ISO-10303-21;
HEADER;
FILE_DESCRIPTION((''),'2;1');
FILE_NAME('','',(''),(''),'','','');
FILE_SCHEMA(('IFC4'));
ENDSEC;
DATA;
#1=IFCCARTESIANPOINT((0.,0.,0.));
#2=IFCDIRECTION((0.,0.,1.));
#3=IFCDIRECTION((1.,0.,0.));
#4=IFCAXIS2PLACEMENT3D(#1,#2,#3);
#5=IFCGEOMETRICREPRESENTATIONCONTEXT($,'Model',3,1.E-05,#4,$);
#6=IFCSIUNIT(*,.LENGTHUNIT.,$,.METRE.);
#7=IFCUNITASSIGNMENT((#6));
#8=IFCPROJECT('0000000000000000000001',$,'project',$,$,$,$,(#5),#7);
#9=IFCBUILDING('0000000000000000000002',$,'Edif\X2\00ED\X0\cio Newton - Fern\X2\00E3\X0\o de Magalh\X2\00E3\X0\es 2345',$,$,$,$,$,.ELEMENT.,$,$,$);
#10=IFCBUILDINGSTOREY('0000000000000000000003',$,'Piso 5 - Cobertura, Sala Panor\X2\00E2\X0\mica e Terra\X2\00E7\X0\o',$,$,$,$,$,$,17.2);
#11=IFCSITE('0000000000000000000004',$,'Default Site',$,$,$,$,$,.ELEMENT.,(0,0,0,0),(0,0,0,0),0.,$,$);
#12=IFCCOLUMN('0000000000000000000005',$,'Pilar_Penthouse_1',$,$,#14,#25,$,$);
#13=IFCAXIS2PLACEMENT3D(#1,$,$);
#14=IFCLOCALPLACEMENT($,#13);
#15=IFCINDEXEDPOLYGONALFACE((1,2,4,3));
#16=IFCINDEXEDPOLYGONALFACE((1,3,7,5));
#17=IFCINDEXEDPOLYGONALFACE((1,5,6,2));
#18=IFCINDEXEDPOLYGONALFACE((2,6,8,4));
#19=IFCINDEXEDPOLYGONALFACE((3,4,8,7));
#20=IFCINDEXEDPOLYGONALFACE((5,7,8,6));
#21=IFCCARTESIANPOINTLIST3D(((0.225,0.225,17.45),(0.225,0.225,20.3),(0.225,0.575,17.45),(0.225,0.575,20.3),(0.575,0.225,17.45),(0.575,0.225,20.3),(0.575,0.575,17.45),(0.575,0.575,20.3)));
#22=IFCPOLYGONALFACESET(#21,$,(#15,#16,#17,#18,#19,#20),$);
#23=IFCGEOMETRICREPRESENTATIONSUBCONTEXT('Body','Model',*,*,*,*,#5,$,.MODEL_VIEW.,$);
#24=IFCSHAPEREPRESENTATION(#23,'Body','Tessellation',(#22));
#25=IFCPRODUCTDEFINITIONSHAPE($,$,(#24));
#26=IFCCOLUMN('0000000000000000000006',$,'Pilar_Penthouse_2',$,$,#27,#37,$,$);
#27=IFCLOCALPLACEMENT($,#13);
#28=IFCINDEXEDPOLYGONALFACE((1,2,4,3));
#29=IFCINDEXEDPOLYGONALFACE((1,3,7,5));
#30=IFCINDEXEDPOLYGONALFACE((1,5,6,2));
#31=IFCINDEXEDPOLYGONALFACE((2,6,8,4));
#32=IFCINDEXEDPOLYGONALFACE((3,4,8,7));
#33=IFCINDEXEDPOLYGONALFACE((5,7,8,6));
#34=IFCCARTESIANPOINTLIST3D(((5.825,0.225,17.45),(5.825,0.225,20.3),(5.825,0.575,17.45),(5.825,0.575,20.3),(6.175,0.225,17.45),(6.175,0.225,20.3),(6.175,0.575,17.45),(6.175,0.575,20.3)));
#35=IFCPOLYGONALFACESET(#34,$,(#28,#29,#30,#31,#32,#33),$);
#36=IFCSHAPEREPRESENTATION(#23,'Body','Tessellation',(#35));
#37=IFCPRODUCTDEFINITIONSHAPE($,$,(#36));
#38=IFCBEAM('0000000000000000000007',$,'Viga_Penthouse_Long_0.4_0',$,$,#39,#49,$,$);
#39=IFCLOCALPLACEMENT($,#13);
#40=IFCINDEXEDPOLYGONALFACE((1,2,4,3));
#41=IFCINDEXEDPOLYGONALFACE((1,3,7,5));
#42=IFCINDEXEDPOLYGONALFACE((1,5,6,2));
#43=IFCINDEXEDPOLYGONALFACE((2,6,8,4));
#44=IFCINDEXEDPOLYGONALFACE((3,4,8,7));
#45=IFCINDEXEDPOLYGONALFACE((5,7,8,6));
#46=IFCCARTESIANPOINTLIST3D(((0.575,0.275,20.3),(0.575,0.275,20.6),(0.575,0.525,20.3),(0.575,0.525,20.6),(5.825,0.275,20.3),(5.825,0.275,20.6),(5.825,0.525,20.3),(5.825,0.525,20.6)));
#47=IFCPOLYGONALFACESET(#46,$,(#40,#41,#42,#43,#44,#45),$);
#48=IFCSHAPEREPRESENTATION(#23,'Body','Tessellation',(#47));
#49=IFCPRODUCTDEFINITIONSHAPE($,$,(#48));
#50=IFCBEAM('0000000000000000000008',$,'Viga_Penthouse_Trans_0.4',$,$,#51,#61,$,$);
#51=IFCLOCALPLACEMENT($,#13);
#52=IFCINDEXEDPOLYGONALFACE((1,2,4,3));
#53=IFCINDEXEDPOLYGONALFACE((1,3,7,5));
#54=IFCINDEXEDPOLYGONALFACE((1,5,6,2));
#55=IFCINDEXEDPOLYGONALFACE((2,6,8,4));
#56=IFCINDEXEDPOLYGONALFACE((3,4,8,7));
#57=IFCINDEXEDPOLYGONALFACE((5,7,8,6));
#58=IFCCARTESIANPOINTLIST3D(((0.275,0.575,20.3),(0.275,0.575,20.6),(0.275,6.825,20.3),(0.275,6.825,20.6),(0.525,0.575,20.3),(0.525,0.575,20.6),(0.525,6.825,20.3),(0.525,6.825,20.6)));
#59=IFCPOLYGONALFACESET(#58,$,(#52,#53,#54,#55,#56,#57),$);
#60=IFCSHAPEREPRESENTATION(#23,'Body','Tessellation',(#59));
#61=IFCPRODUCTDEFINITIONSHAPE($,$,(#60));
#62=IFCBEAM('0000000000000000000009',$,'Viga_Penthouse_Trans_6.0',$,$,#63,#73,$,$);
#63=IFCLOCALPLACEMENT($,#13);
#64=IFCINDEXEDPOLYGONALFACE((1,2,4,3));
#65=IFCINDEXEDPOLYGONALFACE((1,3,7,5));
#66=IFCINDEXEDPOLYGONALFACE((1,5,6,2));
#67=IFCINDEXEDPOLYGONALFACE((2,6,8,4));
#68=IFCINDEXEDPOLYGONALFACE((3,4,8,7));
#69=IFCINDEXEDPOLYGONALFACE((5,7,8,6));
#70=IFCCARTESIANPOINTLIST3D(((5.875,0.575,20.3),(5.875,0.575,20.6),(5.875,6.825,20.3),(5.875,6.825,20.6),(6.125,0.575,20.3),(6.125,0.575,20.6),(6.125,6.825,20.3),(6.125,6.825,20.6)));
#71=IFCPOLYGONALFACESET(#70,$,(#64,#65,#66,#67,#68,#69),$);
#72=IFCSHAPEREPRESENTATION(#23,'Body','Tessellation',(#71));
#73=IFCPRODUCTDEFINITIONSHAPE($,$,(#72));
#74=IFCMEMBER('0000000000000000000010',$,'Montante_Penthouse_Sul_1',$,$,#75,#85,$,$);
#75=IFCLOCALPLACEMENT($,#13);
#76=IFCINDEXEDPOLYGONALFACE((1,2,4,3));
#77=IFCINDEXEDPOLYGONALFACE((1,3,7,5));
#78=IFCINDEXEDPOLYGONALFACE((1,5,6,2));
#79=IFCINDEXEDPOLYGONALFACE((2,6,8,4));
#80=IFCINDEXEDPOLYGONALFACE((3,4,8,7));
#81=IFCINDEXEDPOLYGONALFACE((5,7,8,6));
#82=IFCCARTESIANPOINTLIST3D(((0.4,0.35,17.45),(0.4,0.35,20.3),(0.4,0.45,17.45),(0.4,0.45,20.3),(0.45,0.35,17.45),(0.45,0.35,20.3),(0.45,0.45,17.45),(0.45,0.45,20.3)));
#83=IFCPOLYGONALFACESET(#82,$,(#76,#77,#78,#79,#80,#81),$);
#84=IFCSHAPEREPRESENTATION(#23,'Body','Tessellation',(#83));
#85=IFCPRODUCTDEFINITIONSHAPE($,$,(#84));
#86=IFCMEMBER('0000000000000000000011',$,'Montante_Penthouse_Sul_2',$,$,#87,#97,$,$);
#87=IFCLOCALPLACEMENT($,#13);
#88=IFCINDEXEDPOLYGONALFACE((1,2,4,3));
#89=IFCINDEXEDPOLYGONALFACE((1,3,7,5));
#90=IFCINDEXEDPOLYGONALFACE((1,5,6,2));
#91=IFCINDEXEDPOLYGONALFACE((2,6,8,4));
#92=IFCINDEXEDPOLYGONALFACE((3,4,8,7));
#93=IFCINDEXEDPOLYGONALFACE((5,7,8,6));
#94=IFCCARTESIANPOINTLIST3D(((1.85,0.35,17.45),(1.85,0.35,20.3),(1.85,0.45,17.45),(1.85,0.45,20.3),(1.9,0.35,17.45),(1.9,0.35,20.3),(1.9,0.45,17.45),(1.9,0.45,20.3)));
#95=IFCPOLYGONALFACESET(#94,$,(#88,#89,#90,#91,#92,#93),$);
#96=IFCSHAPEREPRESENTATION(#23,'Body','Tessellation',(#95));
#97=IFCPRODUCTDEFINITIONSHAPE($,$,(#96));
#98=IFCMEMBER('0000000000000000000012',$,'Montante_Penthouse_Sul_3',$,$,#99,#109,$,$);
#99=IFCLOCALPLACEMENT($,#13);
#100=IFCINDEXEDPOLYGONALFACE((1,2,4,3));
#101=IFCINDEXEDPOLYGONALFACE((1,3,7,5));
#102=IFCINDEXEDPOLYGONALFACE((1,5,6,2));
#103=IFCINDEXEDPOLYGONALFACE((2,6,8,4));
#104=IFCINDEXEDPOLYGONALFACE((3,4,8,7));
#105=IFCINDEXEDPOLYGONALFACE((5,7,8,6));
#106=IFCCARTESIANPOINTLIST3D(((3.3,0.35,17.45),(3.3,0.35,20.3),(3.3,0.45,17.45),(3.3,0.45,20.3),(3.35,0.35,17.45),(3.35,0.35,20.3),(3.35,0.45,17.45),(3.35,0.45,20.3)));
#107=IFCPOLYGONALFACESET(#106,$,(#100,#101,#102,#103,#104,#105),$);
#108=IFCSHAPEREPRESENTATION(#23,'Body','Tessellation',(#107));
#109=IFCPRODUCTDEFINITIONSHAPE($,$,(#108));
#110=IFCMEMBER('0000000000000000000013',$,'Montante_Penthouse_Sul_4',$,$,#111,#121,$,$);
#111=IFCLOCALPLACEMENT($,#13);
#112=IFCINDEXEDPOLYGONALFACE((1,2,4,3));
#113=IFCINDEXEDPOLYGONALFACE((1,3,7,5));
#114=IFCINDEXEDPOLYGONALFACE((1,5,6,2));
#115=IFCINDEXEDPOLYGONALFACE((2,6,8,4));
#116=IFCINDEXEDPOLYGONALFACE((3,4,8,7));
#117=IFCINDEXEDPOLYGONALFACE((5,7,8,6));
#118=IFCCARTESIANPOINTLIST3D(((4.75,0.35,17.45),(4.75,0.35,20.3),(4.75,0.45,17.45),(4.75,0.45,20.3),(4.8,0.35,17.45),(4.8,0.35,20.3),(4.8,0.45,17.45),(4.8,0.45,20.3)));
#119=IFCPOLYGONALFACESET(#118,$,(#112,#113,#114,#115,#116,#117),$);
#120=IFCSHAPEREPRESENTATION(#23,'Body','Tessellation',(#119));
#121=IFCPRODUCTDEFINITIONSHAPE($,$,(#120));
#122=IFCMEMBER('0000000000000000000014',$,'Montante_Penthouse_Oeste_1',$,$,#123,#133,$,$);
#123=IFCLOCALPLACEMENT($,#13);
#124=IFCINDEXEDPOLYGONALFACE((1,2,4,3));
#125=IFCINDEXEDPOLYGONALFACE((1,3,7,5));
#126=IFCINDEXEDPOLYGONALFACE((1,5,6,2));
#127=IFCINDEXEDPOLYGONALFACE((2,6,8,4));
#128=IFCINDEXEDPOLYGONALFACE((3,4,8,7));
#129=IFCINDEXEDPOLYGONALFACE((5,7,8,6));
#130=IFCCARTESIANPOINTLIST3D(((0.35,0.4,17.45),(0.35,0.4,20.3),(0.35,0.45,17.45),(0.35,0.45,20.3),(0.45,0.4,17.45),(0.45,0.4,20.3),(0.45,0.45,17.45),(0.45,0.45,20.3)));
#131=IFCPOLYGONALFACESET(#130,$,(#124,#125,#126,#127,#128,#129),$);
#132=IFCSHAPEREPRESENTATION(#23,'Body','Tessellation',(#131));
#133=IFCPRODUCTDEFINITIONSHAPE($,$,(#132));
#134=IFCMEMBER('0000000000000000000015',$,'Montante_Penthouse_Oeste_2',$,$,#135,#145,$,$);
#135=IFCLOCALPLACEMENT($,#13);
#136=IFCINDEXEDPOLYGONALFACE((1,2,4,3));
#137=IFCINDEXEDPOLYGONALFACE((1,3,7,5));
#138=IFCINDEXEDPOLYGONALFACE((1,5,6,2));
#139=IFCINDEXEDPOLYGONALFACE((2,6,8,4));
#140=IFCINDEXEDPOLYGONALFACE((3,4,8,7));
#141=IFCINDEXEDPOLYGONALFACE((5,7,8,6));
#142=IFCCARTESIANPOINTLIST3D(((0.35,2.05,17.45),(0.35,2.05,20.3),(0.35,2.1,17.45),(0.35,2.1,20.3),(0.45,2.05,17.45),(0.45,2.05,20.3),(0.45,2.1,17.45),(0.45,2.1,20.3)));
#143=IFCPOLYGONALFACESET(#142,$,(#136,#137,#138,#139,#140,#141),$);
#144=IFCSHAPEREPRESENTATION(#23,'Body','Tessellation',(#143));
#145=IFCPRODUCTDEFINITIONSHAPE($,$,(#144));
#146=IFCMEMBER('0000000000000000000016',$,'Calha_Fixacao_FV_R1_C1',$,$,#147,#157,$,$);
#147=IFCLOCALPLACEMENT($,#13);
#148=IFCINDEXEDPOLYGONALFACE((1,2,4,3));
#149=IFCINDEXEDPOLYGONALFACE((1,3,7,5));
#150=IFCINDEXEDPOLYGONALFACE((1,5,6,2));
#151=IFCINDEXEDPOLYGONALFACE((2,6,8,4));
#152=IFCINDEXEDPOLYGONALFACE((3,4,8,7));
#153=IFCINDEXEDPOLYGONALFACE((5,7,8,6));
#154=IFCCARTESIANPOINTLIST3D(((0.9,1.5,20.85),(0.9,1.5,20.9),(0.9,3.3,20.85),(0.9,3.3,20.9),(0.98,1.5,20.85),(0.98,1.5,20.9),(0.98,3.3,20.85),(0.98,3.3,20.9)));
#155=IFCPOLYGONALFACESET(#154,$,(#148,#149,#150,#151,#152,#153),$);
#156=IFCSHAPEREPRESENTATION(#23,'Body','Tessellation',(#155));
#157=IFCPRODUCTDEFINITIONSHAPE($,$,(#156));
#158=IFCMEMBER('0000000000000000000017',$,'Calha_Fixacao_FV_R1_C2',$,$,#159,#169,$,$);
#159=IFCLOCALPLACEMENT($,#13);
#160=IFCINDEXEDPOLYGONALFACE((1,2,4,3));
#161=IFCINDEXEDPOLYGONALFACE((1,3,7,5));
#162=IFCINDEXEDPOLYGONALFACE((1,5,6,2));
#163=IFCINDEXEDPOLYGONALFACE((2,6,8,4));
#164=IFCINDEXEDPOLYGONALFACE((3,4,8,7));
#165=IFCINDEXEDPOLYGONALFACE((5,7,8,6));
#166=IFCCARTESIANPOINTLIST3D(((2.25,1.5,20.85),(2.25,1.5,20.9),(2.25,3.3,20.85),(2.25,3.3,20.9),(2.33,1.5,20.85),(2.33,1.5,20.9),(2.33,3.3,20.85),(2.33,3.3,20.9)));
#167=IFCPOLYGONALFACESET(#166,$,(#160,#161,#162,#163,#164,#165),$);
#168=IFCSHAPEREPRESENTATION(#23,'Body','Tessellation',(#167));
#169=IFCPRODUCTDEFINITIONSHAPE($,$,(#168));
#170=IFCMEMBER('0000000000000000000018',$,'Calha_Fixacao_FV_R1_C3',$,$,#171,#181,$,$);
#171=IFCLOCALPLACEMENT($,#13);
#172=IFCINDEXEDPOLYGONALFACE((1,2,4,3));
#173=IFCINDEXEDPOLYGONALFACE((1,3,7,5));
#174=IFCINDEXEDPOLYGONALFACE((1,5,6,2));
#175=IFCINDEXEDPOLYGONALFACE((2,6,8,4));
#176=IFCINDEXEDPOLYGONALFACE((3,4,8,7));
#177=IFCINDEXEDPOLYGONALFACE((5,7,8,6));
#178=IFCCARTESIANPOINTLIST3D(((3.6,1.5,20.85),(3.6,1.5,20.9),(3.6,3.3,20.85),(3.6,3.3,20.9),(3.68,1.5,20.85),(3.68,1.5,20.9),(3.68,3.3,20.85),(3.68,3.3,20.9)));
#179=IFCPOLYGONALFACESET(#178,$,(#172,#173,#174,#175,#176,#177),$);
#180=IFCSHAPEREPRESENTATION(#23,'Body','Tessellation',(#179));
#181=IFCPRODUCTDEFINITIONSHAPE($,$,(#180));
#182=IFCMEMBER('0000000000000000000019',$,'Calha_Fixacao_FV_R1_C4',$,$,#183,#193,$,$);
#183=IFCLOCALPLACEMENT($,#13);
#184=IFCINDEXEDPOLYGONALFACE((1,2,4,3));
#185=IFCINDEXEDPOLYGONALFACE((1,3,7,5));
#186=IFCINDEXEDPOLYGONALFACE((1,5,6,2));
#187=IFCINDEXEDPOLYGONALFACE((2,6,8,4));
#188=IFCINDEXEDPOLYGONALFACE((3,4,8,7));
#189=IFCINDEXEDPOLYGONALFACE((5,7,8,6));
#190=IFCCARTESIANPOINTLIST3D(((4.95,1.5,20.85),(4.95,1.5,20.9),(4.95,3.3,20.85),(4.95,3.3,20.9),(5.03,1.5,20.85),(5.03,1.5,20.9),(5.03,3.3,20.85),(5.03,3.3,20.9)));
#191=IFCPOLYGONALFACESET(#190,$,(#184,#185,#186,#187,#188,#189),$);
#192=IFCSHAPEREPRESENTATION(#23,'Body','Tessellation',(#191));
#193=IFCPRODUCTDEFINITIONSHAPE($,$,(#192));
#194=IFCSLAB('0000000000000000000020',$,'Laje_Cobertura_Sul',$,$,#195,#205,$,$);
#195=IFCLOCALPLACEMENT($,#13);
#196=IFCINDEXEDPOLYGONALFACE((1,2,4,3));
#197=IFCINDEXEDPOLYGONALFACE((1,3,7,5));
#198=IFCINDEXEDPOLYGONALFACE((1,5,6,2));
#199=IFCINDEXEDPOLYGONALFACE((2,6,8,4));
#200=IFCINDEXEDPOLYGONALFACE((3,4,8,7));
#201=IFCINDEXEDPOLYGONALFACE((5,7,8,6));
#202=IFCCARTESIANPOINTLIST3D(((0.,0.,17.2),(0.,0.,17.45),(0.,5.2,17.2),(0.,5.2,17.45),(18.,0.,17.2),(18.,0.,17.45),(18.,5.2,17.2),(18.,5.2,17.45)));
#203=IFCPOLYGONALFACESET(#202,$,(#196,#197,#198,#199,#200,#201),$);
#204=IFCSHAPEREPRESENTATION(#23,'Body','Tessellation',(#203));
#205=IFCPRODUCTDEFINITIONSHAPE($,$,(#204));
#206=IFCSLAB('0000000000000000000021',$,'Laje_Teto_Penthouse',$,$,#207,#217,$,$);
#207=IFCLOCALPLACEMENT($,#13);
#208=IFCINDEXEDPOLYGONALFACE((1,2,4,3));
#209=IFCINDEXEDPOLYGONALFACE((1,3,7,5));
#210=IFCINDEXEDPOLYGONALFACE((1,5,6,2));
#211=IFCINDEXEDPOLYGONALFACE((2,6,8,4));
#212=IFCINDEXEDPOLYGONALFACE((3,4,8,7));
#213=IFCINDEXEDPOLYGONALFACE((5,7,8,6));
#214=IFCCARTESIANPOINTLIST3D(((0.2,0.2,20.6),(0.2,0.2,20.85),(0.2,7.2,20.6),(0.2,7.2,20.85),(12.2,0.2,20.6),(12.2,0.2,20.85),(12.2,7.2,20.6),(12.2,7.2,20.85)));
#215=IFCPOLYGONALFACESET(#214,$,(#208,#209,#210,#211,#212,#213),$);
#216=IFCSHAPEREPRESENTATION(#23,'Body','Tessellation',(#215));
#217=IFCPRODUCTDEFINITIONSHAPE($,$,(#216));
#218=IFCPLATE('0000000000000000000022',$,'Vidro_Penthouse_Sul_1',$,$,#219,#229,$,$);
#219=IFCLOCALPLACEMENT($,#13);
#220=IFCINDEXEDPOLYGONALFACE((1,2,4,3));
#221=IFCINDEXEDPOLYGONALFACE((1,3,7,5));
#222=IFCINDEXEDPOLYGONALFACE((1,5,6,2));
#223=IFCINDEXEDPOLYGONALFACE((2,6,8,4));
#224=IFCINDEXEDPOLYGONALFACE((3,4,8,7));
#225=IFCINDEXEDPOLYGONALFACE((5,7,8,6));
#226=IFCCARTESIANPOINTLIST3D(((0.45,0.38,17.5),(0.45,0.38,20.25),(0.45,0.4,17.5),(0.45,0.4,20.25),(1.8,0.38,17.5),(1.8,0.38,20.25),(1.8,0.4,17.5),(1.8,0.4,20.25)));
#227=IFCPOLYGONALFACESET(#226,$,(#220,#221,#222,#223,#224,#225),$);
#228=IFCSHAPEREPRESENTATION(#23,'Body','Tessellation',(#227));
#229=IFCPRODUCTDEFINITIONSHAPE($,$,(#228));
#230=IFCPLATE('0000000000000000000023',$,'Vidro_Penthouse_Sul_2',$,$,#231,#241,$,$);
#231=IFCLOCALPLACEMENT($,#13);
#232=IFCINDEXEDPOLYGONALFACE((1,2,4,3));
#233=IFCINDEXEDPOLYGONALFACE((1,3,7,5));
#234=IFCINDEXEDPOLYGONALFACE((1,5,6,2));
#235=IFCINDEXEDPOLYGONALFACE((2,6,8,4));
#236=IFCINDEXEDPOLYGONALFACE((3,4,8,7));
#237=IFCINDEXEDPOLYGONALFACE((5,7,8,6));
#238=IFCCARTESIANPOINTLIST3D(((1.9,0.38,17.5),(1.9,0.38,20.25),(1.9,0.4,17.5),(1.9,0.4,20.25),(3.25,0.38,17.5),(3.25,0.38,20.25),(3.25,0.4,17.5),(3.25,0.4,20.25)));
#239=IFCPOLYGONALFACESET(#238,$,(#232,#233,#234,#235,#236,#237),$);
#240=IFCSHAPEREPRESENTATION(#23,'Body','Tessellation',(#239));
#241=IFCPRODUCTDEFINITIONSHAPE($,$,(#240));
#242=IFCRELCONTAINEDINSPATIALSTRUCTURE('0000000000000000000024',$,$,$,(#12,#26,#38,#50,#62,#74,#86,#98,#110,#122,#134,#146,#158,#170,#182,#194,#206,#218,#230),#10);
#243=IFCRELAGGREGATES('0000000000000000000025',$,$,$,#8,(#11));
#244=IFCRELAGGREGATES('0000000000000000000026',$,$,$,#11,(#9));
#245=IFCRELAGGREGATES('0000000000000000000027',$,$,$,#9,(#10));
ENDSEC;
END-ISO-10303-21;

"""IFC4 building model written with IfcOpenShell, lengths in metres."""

from ifc_helpers import new_model, si_unit, frame, frame_2d, origin_with_axes, place, context, subcontext, project, spatial, rectangle, extrude, element, save


model = new_model("IFC4")

# Units and contexts
model_context = context("Model", 3, precision=1e-05, world=origin_with_axes())
body_context = subcontext(model_context, "Body", "Model", "MODEL_VIEW")
ifc_project = project(units=[si_unit("LENGTHUNIT", "METRE")], contexts=[model_context])

# Site, building, storey
site = spatial("IfcSite", under=ifc_project, Name="Default Site", CompositionType="ELEMENT", RefLatitude=(0, 0, 0, 0), RefLongitude=(0, 0, 0, 0), RefElevation=0.0)
building = spatial("IfcBuilding", under=site, Name="Edifício Newton - Fernão de Magalhães 2345", CompositionType="ELEMENT")
storey = spatial("IfcBuildingStorey", under=building, Name="Piso 5 - Cobertura, Sala Panorâmica e Terraço", Elevation=17.2)

# Columns
for number, where, z_axis, x_axis, name in (
    (1, (0.225, 0.225, 17.45), (0.0, 0.0, 1.0), (1.0, 0.0, 0.0), "Pilar_Penthouse_1"),
    (2, (5.825, 0.225, 17.45), (0.0, 0.0, 1.0), (1.0, 0.0, 0.0), "Pilar_Penthouse_2"),
):
    element("IfcColumn", number, at=place(None, frame(where, z_axis=z_axis, x_axis=x_axis)), inside=storey, Name=name, context=body_context, shape_type="SweptSolid", body=[
        extrude(rectangle(XDim=0.35, YDim=0.35, at=frame_2d((0.175, 0.175))), origin_with_axes(), (0.0, 0.0, 1.0), 2.85),
    ])

# Beams
beam_placement = place(None, frame((0.575, 0.275, 20.3), z_axis=(0.0, 0.0, 1.0), x_axis=(1.0, 0.0, 0.0)))
element("IfcBeam", 3, at=beam_placement, inside=storey, Name="Viga_Penthouse_Long_0.4_0", context=body_context, shape_type="SweptSolid", body=[
    extrude(rectangle(XDim=5.25, YDim=0.25, at=frame_2d((2.625, 0.125))), origin_with_axes(), (0.0, 0.0, 1.0), 0.3),
])
for number, where, z_axis, x_axis, name in (
    (4, (0.275, 0.575, 20.3), (0.0, 0.0, 1.0), (1.0, 0.0, 0.0), "Viga_Penthouse_Trans_0.4"),
    (5, (5.875, 0.575, 20.3), (0.0, 0.0, 1.0), (1.0, 0.0, 0.0), "Viga_Penthouse_Trans_6.0"),
):
    element("IfcBeam", number, at=place(None, frame(where, z_axis=z_axis, x_axis=x_axis)), inside=storey, Name=name, context=body_context, shape_type="SweptSolid", body=[
        extrude(rectangle(XDim=0.25, YDim=6.25, at=frame_2d((0.125, 3.125))), origin_with_axes(), (0.0, 0.0, 1.0), 0.3),
    ])

# Members
for number, where, z_axis, x_axis, name in (
    (6, (0.4, 0.35, 17.45), (0.0, 0.0, 1.0), (1.0, 0.0, 0.0), "Montante_Penthouse_Sul_1"),
    (7, (1.85, 0.35, 17.45), (0.0, 0.0, 1.0), (1.0, 0.0, 0.0), "Montante_Penthouse_Sul_2"),
    (8, (3.3, 0.35, 17.45), (0.0, 0.0, 1.0), (1.0, 0.0, 0.0), "Montante_Penthouse_Sul_3"),
    (9, (4.75, 0.35, 17.45), (0.0, 0.0, 1.0), (1.0, 0.0, 0.0), "Montante_Penthouse_Sul_4"),
):
    element("IfcMember", number, at=place(None, frame(where, z_axis=z_axis, x_axis=x_axis)), inside=storey, Name=name, context=body_context, shape_type="SweptSolid", body=[
        extrude(rectangle(XDim=0.05, YDim=0.1, at=frame_2d((0.025, 0.05))), origin_with_axes(), (0.0, 0.0, 1.0), 2.85),
    ])
for number, where, z_axis, x_axis, name in (
    (10, (0.35, 0.4, 17.45), (0.0, 0.0, 1.0), (1.0, 0.0, 0.0), "Montante_Penthouse_Oeste_1"),
    (11, (0.35, 2.05, 17.45), (0.0, 0.0, 1.0), (1.0, 0.0, 0.0), "Montante_Penthouse_Oeste_2"),
):
    element("IfcMember", number, at=place(None, frame(where, z_axis=z_axis, x_axis=x_axis)), inside=storey, Name=name, context=body_context, shape_type="SweptSolid", body=[
        extrude(rectangle(XDim=0.1, YDim=0.05, at=frame_2d((0.05, 0.025))), origin_with_axes(), (0.0, 0.0, 1.0), 2.85),
    ])
for number, where, z_axis, x_axis, name in (
    (12, (0.9, 1.5, 20.85), (0.0, 0.0, 1.0), (1.0, 0.0, 0.0), "Calha_Fixacao_FV_R1_C1"),
    (13, (2.25, 1.5, 20.85), (0.0, 0.0, 1.0), (1.0, 0.0, 0.0), "Calha_Fixacao_FV_R1_C2"),
    (14, (3.6, 1.5, 20.85), (0.0, 0.0, 1.0), (1.0, 0.0, 0.0), "Calha_Fixacao_FV_R1_C3"),
    (15, (4.95, 1.5, 20.85), (0.0, 0.0, 1.0), (1.0, 0.0, 0.0), "Calha_Fixacao_FV_R1_C4"),
):
    element("IfcMember", number, at=place(None, frame(where, z_axis=z_axis, x_axis=x_axis)), inside=storey, Name=name, context=body_context, shape_type="SweptSolid", body=[
        extrude(rectangle(XDim=0.08, YDim=1.8, at=frame_2d((0.04, 0.9))), origin_with_axes(), (0.0, 0.0, 1.0), 0.05),
    ])

# Slabs
slab_1_placement = place(None, frame((0.0, 0.0, 17.2), z_axis=(0.0, 0.0, 1.0), x_axis=(1.0, 0.0, 0.0)))
element("IfcSlab", 16, at=slab_1_placement, inside=storey, Name="Laje_Cobertura_Sul", context=body_context, shape_type="SweptSolid", body=[
    extrude(rectangle(XDim=18.0, YDim=5.2, at=frame_2d((9.0, 2.6))), origin_with_axes(), (0.0, 0.0, 1.0), 0.25),
])
slab_2_placement = place(None, frame((0.2, 0.2, 20.6), z_axis=(0.0, 0.0, 1.0), x_axis=(1.0, 0.0, 0.0)))
element("IfcSlab", 17, at=slab_2_placement, inside=storey, Name="Laje_Teto_Penthouse", context=body_context, shape_type="SweptSolid", body=[
    extrude(rectangle(XDim=12.0, YDim=7.0, at=frame_2d((6.0, 3.5))), origin_with_axes(), (0.0, 0.0, 1.0), 0.25),
])

# Plates
for number, where, z_axis, x_axis, name in (
    (18, (0.45, 0.38, 17.5), (0.0, 0.0, 1.0), (1.0, 0.0, 0.0), "Vidro_Penthouse_Sul_1"),
    (19, (1.9, 0.38, 17.5), (0.0, 0.0, 1.0), (1.0, 0.0, 0.0), "Vidro_Penthouse_Sul_2"),
):
    element("IfcPlate", number, at=place(None, frame(where, z_axis=z_axis, x_axis=x_axis)), inside=storey, Name=name, context=body_context, shape_type="SweptSolid", body=[
        extrude(rectangle(XDim=1.35, YDim=0.02, at=frame_2d((0.675, 0.01))), origin_with_axes(), (0.0, 0.0, 1.0), 2.75),
    ])

save(model, "model.ifc")
